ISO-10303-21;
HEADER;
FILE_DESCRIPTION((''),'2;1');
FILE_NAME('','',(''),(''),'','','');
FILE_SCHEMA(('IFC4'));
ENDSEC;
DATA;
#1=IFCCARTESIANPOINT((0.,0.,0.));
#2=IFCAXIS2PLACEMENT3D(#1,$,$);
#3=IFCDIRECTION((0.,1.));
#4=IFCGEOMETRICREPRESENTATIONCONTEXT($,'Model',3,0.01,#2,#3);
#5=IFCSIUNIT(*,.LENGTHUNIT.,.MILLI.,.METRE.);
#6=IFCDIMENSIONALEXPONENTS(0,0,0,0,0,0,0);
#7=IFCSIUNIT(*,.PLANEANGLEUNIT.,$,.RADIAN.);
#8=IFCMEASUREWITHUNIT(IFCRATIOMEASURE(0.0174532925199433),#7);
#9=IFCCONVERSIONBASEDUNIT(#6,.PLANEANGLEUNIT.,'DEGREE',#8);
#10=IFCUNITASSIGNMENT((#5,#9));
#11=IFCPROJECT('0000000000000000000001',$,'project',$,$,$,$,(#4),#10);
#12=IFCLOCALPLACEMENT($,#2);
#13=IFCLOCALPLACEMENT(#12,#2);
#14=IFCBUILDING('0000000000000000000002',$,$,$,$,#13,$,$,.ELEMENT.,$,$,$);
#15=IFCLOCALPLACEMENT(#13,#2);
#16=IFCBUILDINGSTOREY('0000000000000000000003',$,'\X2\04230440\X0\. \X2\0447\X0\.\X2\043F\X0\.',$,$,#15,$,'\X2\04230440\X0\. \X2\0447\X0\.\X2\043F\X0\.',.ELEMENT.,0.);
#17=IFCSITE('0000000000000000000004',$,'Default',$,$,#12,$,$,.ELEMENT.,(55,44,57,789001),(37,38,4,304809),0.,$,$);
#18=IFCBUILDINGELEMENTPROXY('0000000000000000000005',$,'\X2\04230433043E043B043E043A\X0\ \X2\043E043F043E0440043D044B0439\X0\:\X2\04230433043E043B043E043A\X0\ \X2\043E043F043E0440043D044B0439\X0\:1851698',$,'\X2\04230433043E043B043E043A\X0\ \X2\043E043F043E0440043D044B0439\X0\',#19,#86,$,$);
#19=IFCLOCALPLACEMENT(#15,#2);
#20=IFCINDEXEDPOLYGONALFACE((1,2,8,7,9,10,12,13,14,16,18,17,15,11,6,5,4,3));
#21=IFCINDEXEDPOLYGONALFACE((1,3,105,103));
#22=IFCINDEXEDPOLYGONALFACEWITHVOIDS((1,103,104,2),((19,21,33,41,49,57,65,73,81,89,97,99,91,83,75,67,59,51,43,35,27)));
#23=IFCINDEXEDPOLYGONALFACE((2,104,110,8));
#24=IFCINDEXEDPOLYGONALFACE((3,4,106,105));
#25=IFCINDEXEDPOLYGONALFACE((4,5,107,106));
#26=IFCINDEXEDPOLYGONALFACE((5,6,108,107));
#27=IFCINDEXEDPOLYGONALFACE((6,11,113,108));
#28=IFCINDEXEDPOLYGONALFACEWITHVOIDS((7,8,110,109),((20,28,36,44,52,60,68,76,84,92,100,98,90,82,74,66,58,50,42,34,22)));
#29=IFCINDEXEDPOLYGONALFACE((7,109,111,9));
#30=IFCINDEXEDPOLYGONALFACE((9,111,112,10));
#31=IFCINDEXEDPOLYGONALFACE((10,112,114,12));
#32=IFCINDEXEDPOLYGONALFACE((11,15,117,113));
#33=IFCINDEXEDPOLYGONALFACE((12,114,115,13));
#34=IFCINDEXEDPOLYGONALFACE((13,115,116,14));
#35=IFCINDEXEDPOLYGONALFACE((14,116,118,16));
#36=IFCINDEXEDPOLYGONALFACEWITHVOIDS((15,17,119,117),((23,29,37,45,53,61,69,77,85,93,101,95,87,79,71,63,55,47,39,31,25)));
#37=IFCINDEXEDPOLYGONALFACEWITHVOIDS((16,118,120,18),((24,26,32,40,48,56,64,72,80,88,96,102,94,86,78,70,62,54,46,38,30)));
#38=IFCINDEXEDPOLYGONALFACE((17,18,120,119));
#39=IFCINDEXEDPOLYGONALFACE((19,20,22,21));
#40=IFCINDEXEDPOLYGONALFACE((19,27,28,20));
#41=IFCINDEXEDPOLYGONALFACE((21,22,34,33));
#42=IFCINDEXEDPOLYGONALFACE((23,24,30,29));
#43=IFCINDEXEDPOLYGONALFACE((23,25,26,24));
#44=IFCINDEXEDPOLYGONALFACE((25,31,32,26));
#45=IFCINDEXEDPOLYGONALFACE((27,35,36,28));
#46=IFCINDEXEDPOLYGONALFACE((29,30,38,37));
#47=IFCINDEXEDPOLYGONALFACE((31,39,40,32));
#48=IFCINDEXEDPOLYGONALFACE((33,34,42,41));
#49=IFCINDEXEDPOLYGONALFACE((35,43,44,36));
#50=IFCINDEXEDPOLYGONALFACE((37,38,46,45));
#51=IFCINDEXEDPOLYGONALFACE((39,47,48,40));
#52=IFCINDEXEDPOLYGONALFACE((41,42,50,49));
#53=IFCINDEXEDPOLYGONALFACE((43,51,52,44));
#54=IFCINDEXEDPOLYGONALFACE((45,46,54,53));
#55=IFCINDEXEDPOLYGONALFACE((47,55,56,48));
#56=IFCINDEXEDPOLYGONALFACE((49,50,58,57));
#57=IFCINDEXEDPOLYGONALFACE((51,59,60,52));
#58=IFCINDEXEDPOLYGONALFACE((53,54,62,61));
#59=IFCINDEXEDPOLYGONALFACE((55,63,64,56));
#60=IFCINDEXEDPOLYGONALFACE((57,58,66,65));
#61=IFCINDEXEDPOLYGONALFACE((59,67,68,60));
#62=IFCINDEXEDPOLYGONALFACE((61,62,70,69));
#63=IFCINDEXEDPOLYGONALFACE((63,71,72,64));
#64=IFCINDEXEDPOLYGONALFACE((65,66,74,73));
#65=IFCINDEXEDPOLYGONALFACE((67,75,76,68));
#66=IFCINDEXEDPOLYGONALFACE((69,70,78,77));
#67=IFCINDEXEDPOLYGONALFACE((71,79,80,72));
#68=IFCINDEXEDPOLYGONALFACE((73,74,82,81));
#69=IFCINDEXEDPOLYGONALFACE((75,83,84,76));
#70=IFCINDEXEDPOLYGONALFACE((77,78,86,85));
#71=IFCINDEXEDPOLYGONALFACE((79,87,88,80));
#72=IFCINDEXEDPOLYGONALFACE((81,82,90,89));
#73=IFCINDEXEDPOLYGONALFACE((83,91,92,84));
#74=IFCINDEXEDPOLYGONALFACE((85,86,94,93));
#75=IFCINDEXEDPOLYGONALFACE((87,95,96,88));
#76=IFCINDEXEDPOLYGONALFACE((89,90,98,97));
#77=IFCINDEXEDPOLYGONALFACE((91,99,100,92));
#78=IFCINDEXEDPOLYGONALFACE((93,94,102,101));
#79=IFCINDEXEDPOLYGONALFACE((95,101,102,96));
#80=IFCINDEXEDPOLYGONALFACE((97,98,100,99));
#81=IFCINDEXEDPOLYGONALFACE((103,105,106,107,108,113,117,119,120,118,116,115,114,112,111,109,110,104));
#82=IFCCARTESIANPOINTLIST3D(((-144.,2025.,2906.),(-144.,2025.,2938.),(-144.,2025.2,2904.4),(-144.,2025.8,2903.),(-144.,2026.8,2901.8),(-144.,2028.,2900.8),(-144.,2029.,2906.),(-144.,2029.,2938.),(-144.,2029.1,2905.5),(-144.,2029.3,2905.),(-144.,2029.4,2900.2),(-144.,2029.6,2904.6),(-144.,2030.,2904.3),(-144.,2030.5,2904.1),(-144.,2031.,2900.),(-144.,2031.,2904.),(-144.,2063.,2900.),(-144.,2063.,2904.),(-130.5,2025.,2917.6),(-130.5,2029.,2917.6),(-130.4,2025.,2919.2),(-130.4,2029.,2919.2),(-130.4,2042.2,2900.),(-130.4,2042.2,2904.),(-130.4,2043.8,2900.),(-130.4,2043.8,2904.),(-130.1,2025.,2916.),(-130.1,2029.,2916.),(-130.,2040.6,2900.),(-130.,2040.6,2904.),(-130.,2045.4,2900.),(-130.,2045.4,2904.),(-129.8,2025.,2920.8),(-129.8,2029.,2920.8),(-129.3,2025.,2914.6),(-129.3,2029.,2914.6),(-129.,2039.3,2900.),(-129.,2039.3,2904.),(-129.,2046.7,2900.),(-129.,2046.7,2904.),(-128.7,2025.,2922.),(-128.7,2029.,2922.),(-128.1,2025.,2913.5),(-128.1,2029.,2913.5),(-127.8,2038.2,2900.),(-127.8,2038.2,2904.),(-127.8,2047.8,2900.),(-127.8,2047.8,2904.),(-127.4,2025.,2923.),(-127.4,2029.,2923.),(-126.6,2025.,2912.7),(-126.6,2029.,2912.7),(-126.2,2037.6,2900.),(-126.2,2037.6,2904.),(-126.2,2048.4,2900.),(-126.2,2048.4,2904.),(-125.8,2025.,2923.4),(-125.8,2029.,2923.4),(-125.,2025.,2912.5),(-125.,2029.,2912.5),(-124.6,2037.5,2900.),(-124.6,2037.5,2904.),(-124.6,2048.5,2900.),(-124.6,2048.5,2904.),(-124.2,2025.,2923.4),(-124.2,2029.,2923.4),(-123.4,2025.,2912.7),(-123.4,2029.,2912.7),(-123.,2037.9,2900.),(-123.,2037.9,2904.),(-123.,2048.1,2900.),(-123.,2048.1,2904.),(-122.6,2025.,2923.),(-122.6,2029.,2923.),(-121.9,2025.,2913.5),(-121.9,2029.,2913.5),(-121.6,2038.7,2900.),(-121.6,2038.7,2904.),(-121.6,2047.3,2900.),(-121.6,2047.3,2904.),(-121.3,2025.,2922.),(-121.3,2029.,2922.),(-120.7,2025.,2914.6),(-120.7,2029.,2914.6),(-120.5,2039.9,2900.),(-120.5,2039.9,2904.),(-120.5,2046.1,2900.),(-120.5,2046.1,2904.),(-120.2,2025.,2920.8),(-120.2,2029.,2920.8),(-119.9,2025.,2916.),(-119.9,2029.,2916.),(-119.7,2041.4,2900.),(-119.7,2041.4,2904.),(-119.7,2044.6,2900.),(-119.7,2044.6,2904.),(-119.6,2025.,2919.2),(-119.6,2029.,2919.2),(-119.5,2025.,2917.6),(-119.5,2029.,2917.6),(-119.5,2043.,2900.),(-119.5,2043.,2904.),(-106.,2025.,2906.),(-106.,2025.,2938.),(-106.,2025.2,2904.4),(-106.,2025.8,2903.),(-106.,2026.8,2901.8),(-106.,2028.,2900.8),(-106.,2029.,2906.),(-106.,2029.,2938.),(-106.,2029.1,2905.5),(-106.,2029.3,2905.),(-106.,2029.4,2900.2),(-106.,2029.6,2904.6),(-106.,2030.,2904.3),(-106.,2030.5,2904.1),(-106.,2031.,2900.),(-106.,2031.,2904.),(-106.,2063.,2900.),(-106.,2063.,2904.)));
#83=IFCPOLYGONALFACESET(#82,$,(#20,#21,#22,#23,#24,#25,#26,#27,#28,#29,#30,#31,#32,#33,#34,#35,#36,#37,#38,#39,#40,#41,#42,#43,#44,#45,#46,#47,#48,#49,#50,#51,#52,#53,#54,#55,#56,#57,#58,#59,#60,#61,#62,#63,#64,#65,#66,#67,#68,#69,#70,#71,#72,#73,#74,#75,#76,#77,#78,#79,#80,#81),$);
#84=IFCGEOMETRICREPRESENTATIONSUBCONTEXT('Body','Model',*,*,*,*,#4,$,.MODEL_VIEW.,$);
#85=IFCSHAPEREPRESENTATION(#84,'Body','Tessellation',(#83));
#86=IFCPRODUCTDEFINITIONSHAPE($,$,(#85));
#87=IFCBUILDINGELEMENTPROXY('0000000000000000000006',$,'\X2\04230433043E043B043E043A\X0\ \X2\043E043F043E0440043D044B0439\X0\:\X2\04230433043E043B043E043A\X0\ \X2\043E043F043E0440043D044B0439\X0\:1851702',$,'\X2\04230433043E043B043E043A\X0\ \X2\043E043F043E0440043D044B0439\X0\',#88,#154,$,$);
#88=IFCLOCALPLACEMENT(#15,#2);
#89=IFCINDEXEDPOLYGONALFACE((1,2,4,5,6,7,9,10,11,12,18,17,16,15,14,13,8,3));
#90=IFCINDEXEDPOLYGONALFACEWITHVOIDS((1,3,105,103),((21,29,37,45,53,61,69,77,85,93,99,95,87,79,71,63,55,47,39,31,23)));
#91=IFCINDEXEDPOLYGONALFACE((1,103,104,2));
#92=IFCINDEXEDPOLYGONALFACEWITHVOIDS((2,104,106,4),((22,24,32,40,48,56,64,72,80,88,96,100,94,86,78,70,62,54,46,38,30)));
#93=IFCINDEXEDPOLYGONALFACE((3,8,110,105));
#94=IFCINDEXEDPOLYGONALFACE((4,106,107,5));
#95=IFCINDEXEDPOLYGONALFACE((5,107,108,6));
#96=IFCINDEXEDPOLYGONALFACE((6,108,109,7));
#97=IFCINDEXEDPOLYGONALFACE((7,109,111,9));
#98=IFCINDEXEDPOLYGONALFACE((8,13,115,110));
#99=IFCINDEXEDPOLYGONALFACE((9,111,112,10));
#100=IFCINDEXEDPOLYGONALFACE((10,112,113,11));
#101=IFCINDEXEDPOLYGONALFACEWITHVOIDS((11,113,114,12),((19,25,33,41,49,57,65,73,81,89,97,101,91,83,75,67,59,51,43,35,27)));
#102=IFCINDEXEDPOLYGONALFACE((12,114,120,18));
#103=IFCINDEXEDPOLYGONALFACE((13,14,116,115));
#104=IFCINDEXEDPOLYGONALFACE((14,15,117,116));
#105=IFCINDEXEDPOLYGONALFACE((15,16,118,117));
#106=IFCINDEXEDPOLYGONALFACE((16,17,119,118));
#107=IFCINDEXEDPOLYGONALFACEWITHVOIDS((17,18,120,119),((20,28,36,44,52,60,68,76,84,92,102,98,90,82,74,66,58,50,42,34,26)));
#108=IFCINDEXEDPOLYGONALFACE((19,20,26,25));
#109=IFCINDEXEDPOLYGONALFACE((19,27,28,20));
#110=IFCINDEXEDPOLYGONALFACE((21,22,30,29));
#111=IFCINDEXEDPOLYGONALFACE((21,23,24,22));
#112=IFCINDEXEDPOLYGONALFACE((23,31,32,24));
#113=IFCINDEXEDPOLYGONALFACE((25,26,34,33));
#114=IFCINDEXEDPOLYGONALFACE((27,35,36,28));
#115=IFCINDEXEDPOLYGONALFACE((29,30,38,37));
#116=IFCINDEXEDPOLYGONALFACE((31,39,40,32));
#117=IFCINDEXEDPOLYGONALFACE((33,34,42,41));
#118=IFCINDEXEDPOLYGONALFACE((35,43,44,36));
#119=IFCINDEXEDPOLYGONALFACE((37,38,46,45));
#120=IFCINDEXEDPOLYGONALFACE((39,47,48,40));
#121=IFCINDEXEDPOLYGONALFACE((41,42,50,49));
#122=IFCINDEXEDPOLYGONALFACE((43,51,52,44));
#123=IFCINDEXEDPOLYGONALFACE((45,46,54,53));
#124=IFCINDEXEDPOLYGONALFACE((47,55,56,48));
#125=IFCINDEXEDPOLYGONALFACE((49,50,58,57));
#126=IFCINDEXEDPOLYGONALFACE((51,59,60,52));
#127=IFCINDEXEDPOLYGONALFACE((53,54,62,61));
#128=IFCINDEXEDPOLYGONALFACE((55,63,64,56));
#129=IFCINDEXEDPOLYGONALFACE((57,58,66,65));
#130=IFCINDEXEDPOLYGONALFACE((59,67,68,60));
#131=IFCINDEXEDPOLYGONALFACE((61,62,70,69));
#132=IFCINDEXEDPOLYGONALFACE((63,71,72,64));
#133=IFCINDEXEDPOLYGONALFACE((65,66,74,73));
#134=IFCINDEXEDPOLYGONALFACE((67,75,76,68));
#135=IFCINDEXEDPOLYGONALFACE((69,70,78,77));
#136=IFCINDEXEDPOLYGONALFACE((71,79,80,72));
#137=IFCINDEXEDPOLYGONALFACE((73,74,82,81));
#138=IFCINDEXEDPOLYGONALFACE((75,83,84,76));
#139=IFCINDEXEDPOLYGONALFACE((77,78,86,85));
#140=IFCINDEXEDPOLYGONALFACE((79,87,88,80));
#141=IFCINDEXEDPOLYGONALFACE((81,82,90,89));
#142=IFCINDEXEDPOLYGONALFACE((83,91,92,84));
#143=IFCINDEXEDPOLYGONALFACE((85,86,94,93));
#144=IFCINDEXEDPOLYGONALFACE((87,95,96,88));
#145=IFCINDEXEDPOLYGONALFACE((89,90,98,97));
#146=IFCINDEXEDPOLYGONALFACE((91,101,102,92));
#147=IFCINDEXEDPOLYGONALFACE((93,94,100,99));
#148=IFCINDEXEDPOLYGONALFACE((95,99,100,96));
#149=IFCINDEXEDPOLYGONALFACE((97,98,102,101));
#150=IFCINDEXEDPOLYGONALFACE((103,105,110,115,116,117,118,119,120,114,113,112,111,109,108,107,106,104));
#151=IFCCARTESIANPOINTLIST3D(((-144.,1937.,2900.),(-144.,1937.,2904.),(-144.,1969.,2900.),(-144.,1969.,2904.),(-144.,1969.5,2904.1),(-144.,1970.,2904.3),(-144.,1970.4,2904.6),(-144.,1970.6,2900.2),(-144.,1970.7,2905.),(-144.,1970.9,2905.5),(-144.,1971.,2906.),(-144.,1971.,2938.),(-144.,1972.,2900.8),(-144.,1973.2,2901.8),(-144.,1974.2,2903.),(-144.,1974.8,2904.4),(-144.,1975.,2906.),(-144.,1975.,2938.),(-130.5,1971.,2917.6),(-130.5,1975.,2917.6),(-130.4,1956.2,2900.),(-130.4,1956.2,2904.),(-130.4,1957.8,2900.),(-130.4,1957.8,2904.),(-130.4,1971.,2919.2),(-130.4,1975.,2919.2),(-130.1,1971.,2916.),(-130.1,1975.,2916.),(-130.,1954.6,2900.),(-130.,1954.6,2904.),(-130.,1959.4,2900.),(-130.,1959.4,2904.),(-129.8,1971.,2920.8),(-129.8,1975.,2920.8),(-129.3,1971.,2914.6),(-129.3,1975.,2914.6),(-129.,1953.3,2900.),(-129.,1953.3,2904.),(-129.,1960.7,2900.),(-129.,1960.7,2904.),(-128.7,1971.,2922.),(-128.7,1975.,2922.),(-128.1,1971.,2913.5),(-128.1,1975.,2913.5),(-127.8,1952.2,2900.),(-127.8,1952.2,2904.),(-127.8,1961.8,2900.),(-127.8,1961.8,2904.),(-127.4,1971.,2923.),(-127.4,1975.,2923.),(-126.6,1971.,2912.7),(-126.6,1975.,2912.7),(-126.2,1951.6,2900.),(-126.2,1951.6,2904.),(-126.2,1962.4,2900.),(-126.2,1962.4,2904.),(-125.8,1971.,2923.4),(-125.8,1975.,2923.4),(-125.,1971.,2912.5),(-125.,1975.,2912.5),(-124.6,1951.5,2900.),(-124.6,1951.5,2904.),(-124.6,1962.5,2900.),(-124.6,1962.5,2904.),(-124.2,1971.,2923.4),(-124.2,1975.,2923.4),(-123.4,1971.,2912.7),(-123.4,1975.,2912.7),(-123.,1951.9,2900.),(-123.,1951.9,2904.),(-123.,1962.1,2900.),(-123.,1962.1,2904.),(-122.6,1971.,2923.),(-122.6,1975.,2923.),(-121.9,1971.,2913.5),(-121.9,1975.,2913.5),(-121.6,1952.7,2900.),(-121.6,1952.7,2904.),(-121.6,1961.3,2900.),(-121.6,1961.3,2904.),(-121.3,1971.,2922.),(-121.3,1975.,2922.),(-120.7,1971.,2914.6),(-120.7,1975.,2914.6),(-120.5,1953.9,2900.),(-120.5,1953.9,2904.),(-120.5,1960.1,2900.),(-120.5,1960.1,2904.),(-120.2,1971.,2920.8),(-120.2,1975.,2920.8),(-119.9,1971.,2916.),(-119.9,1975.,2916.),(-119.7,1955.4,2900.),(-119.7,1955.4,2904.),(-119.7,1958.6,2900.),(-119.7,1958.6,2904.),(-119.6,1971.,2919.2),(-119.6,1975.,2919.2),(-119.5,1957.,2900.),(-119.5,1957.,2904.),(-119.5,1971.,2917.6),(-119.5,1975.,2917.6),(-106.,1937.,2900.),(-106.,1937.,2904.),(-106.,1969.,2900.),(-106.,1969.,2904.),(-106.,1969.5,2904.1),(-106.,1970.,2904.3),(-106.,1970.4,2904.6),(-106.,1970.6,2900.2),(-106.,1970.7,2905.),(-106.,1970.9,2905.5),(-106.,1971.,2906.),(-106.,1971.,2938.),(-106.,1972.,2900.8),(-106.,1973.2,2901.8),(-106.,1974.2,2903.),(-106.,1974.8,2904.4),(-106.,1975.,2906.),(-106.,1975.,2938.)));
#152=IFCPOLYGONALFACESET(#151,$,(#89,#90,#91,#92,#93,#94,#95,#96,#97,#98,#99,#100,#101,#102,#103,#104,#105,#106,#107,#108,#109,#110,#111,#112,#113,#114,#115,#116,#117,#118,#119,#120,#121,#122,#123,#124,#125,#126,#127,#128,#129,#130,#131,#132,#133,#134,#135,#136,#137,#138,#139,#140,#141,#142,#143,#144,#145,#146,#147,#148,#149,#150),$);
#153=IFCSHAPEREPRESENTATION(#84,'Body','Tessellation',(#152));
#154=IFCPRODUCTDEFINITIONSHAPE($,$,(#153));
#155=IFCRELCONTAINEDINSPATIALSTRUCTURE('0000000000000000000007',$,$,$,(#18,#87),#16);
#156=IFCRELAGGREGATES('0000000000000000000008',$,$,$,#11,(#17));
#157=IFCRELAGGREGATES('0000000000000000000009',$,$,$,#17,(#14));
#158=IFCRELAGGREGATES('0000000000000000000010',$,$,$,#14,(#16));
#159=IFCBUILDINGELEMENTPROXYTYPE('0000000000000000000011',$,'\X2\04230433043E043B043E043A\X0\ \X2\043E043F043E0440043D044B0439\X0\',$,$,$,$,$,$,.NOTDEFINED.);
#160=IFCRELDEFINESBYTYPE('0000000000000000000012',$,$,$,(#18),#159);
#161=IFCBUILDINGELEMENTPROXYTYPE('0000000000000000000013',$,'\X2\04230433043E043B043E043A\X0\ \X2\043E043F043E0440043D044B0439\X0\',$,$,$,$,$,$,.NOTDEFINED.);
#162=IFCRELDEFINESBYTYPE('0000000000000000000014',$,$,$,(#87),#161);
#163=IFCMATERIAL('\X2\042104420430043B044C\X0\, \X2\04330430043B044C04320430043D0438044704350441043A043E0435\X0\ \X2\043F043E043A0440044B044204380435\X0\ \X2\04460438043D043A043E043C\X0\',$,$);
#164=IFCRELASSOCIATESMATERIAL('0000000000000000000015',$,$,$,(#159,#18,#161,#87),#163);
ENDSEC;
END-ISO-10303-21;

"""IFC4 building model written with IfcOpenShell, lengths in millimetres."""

from ifc_helpers import new_model, entity, si_unit, converted_unit, direction, frame, frame_2d, origin, place, context, subcontext, project, spatial, polyline, circle_curve, parameter, trimmed, segment, composite_curve, circle, outline, extrude, source, transform, mapped, material, type_object, type_shapes, element, save


model = new_model("IFC4")

# Units and contexts
model_context = context("Model", 3, precision=0.01, world=origin(), true_north=direction((0.0, 1.0)))
body_context = subcontext(model_context, "Body", "Model", "MODEL_VIEW")
ifc_project = project(units=[si_unit("LENGTHUNIT", "METRE", prefix="MILLI"), converted_unit("PLANEANGLEUNIT", "DEGREE", entity("IfcRatioMeasure", 0.0174532925199433), si_unit("PLANEANGLEUNIT", "RADIAN"), dimensions=[0, 0, 0, 0, 0, 0, 0])], contexts=[model_context])

# Site, building, storey
site_placement = place(None, origin())
site = spatial("IfcSite", under=ifc_project, at=site_placement, Name="Default", CompositionType="ELEMENT", RefLatitude=(55, 44, 57, 789001), RefLongitude=(37, 38, 4, 304809), RefElevation=0.0)
building_placement = place(site_placement, origin())
building = spatial("IfcBuilding", under=site, at=building_placement, CompositionType="ELEMENT")
storey_placement = place(building_placement, origin())
storey = spatial("IfcBuildingStorey", under=building, at=storey_placement, Name="Ур. ч.п.", LongName="Ур. ч.п.", CompositionType="ELEMENT", Elevation=0.0)

# Building element proxies, openings
ifc_material_1 = material(Name="Сталь, гальваническое покрытие цинком")
building_element_proxy_type_1 = type_object("IfcBuildingElementProxyType", Name="Уголок опорный", material=ifc_material_1)
shared_shape_1 = source(origin(), body_context, "Body", "SweptSolid", [
    extrude(outline(composite_curve([segment(polyline([(-6.0, -12.0), (26.0, -12.0)]), True, "CONTINUOUS"), segment(polyline([(26.0, -12.0), (26.0, -8.0)]), True, "CONTINUOUS"), segment(polyline([(26.0, -8.0), (-6.0, -8.0)]), True, "CONTINUOUS"), segment(trimmed(circle_curve(frame_2d((-6.0, -6.0), x_axis=(0.0, -1.0)), 2.0), [parameter(270.0)], [parameter(0.0)], True, "PARAMETER"), False, "CONTINUOUS"), segment(polyline([(-8.0, -6.0), (-8.0, 26.0)]), True, "CONTINUOUS"), segment(polyline([(-8.0, 26.0), (-12.0, 26.0)]), True, "CONTINUOUS"), segment(polyline([(-12.0, 26.0), (-12.0, -6.0)]), True, "CONTINUOUS"), segment(trimmed(circle_curve(frame_2d((-6.0, -6.0), x_axis=(0.0, -1.0)), 6.0), [parameter(270.0)], [parameter(360.0)], True, "PARAMETER"), True, "CONTINUOUS")], self_intersect=False)), frame((12.0, -19.0, 12.0), z_axis=(0.0, 1.0, 0.0), x_axis=(0.0, 0.0, 1.0)), (0.0, 0.0, 1.0), 38.0),
])
type_shapes(building_element_proxy_type_1, [shared_shape_1])
proxy_1_placement = place(storey_placement, frame((-125.0, 2025.0, 2900.0), z_axis=(0.0, 0.0, 1.0), x_axis=(0.0, 1.0, 0.0)))
proxy_1 = element("IfcBuildingElementProxy", 1, at=proxy_1_placement, inside=storey, type_object=building_element_proxy_type_1, material=ifc_material_1, Name="Уголок опорный:Уголок опорный:1851698", ObjectType="Уголок опорный", context=body_context, shape_type="MappedRepresentation", body=[
    mapped(shared_shape_1, transform((0.0, 0.0, 0.0), scale=1.0)),
])
opening_1_placement = place(storey_placement, frame((-125.0, 2025.0, 2900.0), z_axis=(0.0, 0.0, 1.0), x_axis=(-1.0, 0.0, 0.0)))
element("IfcOpeningElement", 2, at=opening_1_placement, cuts=proxy_1, ObjectType="Opening", PredefinedType="OPENING", context=body_context, shape_type="SweptSolid", body=[
    extrude(circle(Radius=5.5, at=frame_2d((0.0, 0.0), x_axis=(1.0, 0.0))), frame((0.0, -4.0, 18.0), z_axis=(0.0, 1.0, 0.0), x_axis=(0.0, 0.0, -1.0)), (0.0, 0.0, 1.0), 4.0),
])
opening_2_placement = place(storey_placement, frame((-125.0, 2025.0, 2900.0), z_axis=(0.0, 0.0, 1.0), x_axis=(-1.0, 0.0, 0.0)))
element("IfcOpeningElement", 3, at=opening_2_placement, cuts=proxy_1, ObjectType="Opening", PredefinedType="OPENING", context=body_context, shape_type="SweptSolid", body=[
    extrude(circle(Radius=5.5, at=frame_2d((0.0, 0.0), x_axis=(1.0, 0.0))), frame((0.0, -18.0, 0.0), z_axis=(0.0, 0.0, 1.0), x_axis=(-1.0, 0.0, 0.0)), (0.0, 0.0, 1.0), 4.0),
])
building_element_proxy_type_2 = type_object("IfcBuildingElementProxyType", Name="Уголок опорный", material=ifc_material_1)
shared_shape_2 = source(origin(), body_context, "Body", "SweptSolid", [
    extrude(outline(composite_curve([segment(polyline([(-6.0, -12.0), (26.0, -12.0)]), True, "CONTINUOUS"), segment(polyline([(26.0, -12.0), (26.0, -8.0)]), True, "CONTINUOUS"), segment(polyline([(26.0, -8.0), (-6.0, -8.0)]), True, "CONTINUOUS"), segment(trimmed(circle_curve(frame_2d((-6.0, -6.0), x_axis=(0.0, -1.0)), 2.0), [parameter(270.0)], [parameter(0.0)], True, "PARAMETER"), False, "CONTINUOUS"), segment(polyline([(-8.0, -6.0), (-8.0, 26.0)]), True, "CONTINUOUS"), segment(polyline([(-8.0, 26.0), (-12.0, 26.0)]), True, "CONTINUOUS"), segment(polyline([(-12.0, 26.0), (-12.0, -6.0)]), True, "CONTINUOUS"), segment(trimmed(circle_curve(frame_2d((-6.0, -6.0), x_axis=(0.0, -1.0)), 6.0), [parameter(270.0)], [parameter(360.0)], True, "PARAMETER"), True, "CONTINUOUS")], self_intersect=False)), frame((12.0, -19.0, 12.0), z_axis=(0.0, 1.0, 0.0), x_axis=(0.0, 0.0, 1.0)), (0.0, 0.0, 1.0), 38.0),
])
type_shapes(building_element_proxy_type_2, [shared_shape_2])
proxy_2_placement = place(storey_placement, frame((-125.0, 1975.0, 2900.0), z_axis=(0.0, 0.0, 1.0), x_axis=(0.0, -1.0, 0.0)))
proxy_2 = element("IfcBuildingElementProxy", 4, at=proxy_2_placement, inside=storey, type_object=building_element_proxy_type_2, material=ifc_material_1, Name="Уголок опорный:Уголок опорный:1851702", ObjectType="Уголок опорный", context=body_context, shape_type="MappedRepresentation", body=[
    mapped(shared_shape_2, transform((0.0, 0.0, 0.0), scale=1.0)),
])
opening_3_placement = place(storey_placement, frame((-125.0, 1975.0, 2900.0), z_axis=(0.0, 0.0, 1.0), x_axis=(-1.0, 0.0, 0.0)))
element("IfcOpeningElement", 5, at=opening_3_placement, cuts=proxy_2, ObjectType="Opening", PredefinedType="OPENING", context=body_context, shape_type="SweptSolid", body=[
    extrude(circle(Radius=5.5, at=frame_2d((0.0, 0.0), x_axis=(1.0, 0.0))), frame((0.0, 4.0, 18.0), z_axis=(0.0, -1.0, 0.0), x_axis=(0.0, 0.0, -1.0)), (0.0, 0.0, 1.0), 4.0),
])
opening_4_placement = place(storey_placement, frame((-125.0, 1975.0, 2900.0), z_axis=(0.0, 0.0, 1.0), x_axis=(-1.0, 0.0, 0.0)))
element("IfcOpeningElement", 6, at=opening_4_placement, cuts=proxy_2, ObjectType="Opening", PredefinedType="OPENING", context=body_context, shape_type="SweptSolid", body=[
    extrude(circle(Radius=5.5, at=frame_2d((0.0, 0.0), x_axis=(1.0, 0.0))), frame((0.0, 18.0, 0.0), z_axis=(0.0, 0.0, 1.0), x_axis=(-1.0, 0.0, 0.0)), (0.0, 0.0, 1.0), 4.0),
])

save(model, "model.ifc")
